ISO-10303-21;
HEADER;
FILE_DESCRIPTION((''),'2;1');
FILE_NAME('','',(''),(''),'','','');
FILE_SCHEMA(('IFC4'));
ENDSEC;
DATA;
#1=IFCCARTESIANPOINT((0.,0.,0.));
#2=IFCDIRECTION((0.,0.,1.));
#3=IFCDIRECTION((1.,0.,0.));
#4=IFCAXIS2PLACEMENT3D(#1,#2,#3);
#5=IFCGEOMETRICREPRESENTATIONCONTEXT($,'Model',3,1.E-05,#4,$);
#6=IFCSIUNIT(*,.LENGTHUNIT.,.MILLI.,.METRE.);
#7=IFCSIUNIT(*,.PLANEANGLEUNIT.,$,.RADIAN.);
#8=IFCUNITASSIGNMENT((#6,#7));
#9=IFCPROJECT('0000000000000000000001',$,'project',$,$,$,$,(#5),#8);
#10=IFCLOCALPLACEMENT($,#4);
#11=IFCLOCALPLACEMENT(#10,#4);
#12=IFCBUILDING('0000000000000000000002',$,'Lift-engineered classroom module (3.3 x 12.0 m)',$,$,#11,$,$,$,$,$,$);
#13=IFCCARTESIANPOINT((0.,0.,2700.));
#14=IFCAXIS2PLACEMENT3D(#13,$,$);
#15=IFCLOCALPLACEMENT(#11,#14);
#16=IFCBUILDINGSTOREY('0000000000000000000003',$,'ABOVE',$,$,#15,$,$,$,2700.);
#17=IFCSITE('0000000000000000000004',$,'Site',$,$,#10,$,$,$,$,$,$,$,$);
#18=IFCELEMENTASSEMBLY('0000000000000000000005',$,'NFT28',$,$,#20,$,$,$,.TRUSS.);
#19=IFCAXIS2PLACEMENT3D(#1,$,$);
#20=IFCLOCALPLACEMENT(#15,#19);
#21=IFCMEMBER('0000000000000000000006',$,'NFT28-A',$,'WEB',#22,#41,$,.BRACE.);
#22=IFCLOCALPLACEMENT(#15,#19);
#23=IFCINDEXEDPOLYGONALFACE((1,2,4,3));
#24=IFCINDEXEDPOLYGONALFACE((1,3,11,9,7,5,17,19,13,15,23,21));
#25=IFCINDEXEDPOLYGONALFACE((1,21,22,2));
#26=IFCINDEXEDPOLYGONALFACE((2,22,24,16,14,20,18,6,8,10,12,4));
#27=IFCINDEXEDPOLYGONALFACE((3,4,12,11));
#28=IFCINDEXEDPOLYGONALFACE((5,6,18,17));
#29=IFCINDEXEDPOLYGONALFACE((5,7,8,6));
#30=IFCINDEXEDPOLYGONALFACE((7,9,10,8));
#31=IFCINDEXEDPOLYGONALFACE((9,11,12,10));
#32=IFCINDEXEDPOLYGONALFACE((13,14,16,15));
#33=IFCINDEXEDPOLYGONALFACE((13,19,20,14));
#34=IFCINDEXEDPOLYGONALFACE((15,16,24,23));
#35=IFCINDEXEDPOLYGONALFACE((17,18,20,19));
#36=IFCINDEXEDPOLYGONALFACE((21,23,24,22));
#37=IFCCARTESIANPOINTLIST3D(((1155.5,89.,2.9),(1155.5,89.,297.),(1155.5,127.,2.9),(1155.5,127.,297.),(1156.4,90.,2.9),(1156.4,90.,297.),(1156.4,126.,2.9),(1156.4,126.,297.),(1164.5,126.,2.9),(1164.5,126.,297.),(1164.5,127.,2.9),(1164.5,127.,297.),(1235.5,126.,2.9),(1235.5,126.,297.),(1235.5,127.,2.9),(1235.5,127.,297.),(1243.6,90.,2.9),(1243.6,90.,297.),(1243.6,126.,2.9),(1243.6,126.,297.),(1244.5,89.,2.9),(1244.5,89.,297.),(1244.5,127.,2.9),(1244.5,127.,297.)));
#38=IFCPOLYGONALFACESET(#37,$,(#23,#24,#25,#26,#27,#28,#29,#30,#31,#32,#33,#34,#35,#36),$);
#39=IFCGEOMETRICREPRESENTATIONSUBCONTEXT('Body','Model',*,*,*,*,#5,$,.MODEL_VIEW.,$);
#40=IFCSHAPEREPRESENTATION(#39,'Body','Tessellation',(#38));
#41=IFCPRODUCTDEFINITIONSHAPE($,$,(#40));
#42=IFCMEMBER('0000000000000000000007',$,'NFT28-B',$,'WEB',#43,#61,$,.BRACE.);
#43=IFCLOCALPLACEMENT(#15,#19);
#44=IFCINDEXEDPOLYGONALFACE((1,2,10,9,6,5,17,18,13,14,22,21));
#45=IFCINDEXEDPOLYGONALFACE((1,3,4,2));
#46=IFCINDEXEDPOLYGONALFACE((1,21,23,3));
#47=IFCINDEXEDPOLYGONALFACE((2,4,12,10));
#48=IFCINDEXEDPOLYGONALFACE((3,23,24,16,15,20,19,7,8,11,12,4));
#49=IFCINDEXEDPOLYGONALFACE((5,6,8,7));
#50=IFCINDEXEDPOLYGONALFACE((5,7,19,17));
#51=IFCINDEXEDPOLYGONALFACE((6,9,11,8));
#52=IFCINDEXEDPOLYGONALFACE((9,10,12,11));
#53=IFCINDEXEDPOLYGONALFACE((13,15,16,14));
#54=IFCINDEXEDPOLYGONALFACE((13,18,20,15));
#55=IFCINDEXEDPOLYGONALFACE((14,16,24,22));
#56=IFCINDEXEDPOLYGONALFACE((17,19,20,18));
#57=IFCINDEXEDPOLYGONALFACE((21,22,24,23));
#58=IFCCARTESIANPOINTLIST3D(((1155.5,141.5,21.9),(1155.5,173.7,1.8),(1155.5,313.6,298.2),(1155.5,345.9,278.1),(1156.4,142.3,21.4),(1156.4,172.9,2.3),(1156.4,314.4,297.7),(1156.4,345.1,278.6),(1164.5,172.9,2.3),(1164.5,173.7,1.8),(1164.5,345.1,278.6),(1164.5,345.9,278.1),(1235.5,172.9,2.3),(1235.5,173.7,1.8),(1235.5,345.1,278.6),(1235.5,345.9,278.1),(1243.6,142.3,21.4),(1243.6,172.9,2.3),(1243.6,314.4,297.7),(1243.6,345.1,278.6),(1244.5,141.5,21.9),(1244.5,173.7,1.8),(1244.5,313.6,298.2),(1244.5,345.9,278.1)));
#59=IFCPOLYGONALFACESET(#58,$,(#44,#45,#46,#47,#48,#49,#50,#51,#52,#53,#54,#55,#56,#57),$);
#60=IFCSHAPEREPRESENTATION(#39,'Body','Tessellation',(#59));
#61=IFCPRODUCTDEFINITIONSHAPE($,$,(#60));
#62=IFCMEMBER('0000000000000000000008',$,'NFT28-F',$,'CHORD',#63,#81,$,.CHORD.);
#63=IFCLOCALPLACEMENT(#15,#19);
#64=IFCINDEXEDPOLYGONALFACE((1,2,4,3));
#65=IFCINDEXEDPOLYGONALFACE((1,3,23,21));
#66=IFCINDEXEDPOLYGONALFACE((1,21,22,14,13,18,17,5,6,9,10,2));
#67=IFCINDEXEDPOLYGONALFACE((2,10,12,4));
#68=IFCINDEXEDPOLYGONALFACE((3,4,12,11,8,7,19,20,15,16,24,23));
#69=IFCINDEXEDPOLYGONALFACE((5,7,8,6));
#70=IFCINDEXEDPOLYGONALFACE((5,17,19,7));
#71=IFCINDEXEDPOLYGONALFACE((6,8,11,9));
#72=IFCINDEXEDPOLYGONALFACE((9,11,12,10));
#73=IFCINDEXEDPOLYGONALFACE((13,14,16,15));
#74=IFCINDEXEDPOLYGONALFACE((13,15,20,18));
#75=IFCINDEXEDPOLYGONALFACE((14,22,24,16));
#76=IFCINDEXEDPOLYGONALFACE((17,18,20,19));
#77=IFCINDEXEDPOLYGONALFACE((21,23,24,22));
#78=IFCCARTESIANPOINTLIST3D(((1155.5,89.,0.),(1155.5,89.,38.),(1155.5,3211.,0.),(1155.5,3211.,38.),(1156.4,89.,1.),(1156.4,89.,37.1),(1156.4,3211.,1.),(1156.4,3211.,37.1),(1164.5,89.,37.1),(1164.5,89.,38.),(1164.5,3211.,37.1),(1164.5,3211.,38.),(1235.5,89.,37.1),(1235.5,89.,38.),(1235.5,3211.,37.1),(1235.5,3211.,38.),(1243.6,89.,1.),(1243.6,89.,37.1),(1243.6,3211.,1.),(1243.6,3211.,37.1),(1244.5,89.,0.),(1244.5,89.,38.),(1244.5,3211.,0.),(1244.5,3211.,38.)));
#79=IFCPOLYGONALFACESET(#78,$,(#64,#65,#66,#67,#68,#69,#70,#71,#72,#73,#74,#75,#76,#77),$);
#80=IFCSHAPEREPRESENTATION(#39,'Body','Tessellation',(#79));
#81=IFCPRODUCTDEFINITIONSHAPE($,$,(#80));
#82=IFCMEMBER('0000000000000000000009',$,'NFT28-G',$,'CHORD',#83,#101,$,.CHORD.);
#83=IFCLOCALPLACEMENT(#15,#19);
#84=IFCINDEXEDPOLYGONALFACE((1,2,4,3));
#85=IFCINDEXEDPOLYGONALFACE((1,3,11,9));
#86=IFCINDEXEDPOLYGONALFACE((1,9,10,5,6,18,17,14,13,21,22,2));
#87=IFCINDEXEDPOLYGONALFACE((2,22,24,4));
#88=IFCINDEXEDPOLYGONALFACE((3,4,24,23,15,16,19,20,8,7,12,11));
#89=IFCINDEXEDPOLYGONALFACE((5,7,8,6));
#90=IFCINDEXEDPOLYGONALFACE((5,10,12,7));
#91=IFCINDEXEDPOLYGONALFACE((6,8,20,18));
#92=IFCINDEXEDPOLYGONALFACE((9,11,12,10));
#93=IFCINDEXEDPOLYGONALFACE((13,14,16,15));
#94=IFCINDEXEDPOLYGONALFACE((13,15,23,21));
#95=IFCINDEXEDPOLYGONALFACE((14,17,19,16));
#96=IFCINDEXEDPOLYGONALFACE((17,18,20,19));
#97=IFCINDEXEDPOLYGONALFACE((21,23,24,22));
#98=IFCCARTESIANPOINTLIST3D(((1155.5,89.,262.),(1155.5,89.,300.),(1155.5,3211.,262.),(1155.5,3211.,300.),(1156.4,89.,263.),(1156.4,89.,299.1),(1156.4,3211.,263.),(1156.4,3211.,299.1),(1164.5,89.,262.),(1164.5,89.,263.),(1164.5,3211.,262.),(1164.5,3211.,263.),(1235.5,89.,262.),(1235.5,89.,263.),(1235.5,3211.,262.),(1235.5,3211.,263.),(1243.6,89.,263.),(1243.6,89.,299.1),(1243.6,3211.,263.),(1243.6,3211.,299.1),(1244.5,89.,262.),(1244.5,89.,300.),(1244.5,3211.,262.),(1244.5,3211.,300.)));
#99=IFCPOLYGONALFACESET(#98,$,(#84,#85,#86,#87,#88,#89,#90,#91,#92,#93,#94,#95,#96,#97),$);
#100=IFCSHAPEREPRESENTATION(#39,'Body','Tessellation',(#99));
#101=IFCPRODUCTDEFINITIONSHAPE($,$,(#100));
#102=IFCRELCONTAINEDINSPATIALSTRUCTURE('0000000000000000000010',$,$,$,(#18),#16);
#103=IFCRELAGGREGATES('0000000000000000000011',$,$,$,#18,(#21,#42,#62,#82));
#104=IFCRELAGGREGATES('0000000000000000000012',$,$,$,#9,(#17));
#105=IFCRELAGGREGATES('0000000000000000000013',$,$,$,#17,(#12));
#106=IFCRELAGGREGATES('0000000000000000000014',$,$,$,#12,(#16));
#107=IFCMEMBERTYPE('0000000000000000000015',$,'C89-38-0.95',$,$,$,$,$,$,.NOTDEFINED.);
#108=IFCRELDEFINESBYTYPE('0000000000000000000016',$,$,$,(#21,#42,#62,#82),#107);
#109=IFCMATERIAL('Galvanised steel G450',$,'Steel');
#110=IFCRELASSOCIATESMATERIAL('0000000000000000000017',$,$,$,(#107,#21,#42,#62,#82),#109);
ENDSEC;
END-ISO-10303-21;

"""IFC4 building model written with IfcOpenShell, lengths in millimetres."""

from ifc_helpers import new_model, si_unit, frame, origin, origin_with_axes, origin_2d, place, context, subcontext, project, spatial, c_section, extrude, material, material_profile, profile_set, profile_usage, type_object, element, aggregate, save


model = new_model("IFC4")

# Units and contexts
model_context = context("Model", 3, precision=1e-05, world=origin_with_axes())
body_context = subcontext(model_context, "Body", "Model", "MODEL_VIEW")
ifc_project = project(units=[si_unit("LENGTHUNIT", "METRE", prefix="MILLI"), si_unit("PLANEANGLEUNIT", "RADIAN")], contexts=[model_context])

# Site, building, storey
site_placement = place(None, origin_with_axes())
site = spatial("IfcSite", under=ifc_project, at=site_placement, Name="Site")
building_placement = place(site_placement, origin_with_axes())
building = spatial("IfcBuilding", under=site, at=building_placement, Name="Lift-engineered classroom module (3.3 x 12.0 m)")
storey_placement = place(building_placement, frame((0.0, 0.0, 2700.0)))
storey = spatial("IfcBuildingStorey", under=building, at=storey_placement, Name="ABOVE", Elevation=2700.0)

# Element assembly, members
ifc_material = material(Name="Galvanised steel G450", Category="Steel")
ifc_material_profile = material_profile(ifc_material, c_section(Depth=89.0, Width=38.0, WallThickness=0.9, Girth=9.0, at=origin_2d()), Name="C89-38-0.95")
ifc_profile_set = profile_set([ifc_material_profile], Name="C89-38-0.95")
ifc_profile_usage = profile_usage(ifc_profile_set)
member_type = type_object("IfcMemberType", Name="C89-38-0.95", PredefinedType="NOTDEFINED", material=ifc_profile_set)
assembly_1_placement = place(storey_placement, frame((1200.0, 89.0, 0.0)))
assembly_1 = element("IfcElementAssembly", 1, at=assembly_1_placement, inside=storey, Name="NFT28", PredefinedType="TRUSS")
member_1_placement = place(assembly_1_placement, frame((0.0, 19.0, 2.9), z_axis=(0.0, 0.0, 1.0), x_axis=(0.0, 1.0, 0.0)))
member_1 = element("IfcMember", 2, at=member_1_placement, type_object=member_type, material=ifc_profile_usage, Name="NFT28-A", ObjectType="WEB", PredefinedType="BRACE", context=body_context, shape_type="SweptSolid", body=[
    extrude(c_section(Depth=89.0, Width=38.0, WallThickness=0.9, Girth=9.0, at=origin_2d()), origin(), (0.0, 0.0, 1.0), 294.1),
])
member_2_placement = place(assembly_1_placement, frame((0.0, 68.6, 11.8), z_axis=(0.0, 0.528797, 0.848748), x_axis=(0.0, 0.848748, -0.528797)))
member_2 = element("IfcMember", 3, at=member_2_placement, type_object=member_type, material=ifc_profile_usage, Name="NFT28-B", ObjectType="WEB", PredefinedType="BRACE", context=body_context, shape_type="SweptSolid", body=[
    extrude(c_section(Depth=89.0, Width=38.0, WallThickness=0.9, Girth=9.0, at=origin_2d()), origin(), (0.0, 0.0, 1.0), 325.6),
])
member_3_placement = place(assembly_1_placement, frame((0.0, 0.0, 19.0), z_axis=(0.0, 1.0, 0.0), x_axis=(0.0, 0.0, 1.0)))
member_3 = element("IfcMember", 4, at=member_3_placement, type_object=member_type, material=ifc_profile_usage, Name="NFT28-F", ObjectType="CHORD", PredefinedType="CHORD", context=body_context, shape_type="SweptSolid", body=[
    extrude(c_section(Depth=89.0, Width=38.0, WallThickness=0.9, Girth=9.0, at=origin_2d()), origin(), (0.0, 0.0, 1.0), 3122.0),
])
member_4_placement = place(assembly_1_placement, frame((0.0, 0.0, 281.0), z_axis=(0.0, 1.0, 0.0), x_axis=(0.0, 0.0, -1.0)))
member_4 = element("IfcMember", 5, at=member_4_placement, type_object=member_type, material=ifc_profile_usage, Name="NFT28-G", ObjectType="CHORD", PredefinedType="CHORD", context=body_context, shape_type="SweptSolid", body=[
    extrude(c_section(Depth=89.0, Width=38.0, WallThickness=0.9, Girth=9.0, at=origin_2d()), origin(), (0.0, 0.0, 1.0), 3122.0),
])
aggregate(assembly_1, [member_1, member_2, member_3, member_4])

save(model, "model.ifc")
